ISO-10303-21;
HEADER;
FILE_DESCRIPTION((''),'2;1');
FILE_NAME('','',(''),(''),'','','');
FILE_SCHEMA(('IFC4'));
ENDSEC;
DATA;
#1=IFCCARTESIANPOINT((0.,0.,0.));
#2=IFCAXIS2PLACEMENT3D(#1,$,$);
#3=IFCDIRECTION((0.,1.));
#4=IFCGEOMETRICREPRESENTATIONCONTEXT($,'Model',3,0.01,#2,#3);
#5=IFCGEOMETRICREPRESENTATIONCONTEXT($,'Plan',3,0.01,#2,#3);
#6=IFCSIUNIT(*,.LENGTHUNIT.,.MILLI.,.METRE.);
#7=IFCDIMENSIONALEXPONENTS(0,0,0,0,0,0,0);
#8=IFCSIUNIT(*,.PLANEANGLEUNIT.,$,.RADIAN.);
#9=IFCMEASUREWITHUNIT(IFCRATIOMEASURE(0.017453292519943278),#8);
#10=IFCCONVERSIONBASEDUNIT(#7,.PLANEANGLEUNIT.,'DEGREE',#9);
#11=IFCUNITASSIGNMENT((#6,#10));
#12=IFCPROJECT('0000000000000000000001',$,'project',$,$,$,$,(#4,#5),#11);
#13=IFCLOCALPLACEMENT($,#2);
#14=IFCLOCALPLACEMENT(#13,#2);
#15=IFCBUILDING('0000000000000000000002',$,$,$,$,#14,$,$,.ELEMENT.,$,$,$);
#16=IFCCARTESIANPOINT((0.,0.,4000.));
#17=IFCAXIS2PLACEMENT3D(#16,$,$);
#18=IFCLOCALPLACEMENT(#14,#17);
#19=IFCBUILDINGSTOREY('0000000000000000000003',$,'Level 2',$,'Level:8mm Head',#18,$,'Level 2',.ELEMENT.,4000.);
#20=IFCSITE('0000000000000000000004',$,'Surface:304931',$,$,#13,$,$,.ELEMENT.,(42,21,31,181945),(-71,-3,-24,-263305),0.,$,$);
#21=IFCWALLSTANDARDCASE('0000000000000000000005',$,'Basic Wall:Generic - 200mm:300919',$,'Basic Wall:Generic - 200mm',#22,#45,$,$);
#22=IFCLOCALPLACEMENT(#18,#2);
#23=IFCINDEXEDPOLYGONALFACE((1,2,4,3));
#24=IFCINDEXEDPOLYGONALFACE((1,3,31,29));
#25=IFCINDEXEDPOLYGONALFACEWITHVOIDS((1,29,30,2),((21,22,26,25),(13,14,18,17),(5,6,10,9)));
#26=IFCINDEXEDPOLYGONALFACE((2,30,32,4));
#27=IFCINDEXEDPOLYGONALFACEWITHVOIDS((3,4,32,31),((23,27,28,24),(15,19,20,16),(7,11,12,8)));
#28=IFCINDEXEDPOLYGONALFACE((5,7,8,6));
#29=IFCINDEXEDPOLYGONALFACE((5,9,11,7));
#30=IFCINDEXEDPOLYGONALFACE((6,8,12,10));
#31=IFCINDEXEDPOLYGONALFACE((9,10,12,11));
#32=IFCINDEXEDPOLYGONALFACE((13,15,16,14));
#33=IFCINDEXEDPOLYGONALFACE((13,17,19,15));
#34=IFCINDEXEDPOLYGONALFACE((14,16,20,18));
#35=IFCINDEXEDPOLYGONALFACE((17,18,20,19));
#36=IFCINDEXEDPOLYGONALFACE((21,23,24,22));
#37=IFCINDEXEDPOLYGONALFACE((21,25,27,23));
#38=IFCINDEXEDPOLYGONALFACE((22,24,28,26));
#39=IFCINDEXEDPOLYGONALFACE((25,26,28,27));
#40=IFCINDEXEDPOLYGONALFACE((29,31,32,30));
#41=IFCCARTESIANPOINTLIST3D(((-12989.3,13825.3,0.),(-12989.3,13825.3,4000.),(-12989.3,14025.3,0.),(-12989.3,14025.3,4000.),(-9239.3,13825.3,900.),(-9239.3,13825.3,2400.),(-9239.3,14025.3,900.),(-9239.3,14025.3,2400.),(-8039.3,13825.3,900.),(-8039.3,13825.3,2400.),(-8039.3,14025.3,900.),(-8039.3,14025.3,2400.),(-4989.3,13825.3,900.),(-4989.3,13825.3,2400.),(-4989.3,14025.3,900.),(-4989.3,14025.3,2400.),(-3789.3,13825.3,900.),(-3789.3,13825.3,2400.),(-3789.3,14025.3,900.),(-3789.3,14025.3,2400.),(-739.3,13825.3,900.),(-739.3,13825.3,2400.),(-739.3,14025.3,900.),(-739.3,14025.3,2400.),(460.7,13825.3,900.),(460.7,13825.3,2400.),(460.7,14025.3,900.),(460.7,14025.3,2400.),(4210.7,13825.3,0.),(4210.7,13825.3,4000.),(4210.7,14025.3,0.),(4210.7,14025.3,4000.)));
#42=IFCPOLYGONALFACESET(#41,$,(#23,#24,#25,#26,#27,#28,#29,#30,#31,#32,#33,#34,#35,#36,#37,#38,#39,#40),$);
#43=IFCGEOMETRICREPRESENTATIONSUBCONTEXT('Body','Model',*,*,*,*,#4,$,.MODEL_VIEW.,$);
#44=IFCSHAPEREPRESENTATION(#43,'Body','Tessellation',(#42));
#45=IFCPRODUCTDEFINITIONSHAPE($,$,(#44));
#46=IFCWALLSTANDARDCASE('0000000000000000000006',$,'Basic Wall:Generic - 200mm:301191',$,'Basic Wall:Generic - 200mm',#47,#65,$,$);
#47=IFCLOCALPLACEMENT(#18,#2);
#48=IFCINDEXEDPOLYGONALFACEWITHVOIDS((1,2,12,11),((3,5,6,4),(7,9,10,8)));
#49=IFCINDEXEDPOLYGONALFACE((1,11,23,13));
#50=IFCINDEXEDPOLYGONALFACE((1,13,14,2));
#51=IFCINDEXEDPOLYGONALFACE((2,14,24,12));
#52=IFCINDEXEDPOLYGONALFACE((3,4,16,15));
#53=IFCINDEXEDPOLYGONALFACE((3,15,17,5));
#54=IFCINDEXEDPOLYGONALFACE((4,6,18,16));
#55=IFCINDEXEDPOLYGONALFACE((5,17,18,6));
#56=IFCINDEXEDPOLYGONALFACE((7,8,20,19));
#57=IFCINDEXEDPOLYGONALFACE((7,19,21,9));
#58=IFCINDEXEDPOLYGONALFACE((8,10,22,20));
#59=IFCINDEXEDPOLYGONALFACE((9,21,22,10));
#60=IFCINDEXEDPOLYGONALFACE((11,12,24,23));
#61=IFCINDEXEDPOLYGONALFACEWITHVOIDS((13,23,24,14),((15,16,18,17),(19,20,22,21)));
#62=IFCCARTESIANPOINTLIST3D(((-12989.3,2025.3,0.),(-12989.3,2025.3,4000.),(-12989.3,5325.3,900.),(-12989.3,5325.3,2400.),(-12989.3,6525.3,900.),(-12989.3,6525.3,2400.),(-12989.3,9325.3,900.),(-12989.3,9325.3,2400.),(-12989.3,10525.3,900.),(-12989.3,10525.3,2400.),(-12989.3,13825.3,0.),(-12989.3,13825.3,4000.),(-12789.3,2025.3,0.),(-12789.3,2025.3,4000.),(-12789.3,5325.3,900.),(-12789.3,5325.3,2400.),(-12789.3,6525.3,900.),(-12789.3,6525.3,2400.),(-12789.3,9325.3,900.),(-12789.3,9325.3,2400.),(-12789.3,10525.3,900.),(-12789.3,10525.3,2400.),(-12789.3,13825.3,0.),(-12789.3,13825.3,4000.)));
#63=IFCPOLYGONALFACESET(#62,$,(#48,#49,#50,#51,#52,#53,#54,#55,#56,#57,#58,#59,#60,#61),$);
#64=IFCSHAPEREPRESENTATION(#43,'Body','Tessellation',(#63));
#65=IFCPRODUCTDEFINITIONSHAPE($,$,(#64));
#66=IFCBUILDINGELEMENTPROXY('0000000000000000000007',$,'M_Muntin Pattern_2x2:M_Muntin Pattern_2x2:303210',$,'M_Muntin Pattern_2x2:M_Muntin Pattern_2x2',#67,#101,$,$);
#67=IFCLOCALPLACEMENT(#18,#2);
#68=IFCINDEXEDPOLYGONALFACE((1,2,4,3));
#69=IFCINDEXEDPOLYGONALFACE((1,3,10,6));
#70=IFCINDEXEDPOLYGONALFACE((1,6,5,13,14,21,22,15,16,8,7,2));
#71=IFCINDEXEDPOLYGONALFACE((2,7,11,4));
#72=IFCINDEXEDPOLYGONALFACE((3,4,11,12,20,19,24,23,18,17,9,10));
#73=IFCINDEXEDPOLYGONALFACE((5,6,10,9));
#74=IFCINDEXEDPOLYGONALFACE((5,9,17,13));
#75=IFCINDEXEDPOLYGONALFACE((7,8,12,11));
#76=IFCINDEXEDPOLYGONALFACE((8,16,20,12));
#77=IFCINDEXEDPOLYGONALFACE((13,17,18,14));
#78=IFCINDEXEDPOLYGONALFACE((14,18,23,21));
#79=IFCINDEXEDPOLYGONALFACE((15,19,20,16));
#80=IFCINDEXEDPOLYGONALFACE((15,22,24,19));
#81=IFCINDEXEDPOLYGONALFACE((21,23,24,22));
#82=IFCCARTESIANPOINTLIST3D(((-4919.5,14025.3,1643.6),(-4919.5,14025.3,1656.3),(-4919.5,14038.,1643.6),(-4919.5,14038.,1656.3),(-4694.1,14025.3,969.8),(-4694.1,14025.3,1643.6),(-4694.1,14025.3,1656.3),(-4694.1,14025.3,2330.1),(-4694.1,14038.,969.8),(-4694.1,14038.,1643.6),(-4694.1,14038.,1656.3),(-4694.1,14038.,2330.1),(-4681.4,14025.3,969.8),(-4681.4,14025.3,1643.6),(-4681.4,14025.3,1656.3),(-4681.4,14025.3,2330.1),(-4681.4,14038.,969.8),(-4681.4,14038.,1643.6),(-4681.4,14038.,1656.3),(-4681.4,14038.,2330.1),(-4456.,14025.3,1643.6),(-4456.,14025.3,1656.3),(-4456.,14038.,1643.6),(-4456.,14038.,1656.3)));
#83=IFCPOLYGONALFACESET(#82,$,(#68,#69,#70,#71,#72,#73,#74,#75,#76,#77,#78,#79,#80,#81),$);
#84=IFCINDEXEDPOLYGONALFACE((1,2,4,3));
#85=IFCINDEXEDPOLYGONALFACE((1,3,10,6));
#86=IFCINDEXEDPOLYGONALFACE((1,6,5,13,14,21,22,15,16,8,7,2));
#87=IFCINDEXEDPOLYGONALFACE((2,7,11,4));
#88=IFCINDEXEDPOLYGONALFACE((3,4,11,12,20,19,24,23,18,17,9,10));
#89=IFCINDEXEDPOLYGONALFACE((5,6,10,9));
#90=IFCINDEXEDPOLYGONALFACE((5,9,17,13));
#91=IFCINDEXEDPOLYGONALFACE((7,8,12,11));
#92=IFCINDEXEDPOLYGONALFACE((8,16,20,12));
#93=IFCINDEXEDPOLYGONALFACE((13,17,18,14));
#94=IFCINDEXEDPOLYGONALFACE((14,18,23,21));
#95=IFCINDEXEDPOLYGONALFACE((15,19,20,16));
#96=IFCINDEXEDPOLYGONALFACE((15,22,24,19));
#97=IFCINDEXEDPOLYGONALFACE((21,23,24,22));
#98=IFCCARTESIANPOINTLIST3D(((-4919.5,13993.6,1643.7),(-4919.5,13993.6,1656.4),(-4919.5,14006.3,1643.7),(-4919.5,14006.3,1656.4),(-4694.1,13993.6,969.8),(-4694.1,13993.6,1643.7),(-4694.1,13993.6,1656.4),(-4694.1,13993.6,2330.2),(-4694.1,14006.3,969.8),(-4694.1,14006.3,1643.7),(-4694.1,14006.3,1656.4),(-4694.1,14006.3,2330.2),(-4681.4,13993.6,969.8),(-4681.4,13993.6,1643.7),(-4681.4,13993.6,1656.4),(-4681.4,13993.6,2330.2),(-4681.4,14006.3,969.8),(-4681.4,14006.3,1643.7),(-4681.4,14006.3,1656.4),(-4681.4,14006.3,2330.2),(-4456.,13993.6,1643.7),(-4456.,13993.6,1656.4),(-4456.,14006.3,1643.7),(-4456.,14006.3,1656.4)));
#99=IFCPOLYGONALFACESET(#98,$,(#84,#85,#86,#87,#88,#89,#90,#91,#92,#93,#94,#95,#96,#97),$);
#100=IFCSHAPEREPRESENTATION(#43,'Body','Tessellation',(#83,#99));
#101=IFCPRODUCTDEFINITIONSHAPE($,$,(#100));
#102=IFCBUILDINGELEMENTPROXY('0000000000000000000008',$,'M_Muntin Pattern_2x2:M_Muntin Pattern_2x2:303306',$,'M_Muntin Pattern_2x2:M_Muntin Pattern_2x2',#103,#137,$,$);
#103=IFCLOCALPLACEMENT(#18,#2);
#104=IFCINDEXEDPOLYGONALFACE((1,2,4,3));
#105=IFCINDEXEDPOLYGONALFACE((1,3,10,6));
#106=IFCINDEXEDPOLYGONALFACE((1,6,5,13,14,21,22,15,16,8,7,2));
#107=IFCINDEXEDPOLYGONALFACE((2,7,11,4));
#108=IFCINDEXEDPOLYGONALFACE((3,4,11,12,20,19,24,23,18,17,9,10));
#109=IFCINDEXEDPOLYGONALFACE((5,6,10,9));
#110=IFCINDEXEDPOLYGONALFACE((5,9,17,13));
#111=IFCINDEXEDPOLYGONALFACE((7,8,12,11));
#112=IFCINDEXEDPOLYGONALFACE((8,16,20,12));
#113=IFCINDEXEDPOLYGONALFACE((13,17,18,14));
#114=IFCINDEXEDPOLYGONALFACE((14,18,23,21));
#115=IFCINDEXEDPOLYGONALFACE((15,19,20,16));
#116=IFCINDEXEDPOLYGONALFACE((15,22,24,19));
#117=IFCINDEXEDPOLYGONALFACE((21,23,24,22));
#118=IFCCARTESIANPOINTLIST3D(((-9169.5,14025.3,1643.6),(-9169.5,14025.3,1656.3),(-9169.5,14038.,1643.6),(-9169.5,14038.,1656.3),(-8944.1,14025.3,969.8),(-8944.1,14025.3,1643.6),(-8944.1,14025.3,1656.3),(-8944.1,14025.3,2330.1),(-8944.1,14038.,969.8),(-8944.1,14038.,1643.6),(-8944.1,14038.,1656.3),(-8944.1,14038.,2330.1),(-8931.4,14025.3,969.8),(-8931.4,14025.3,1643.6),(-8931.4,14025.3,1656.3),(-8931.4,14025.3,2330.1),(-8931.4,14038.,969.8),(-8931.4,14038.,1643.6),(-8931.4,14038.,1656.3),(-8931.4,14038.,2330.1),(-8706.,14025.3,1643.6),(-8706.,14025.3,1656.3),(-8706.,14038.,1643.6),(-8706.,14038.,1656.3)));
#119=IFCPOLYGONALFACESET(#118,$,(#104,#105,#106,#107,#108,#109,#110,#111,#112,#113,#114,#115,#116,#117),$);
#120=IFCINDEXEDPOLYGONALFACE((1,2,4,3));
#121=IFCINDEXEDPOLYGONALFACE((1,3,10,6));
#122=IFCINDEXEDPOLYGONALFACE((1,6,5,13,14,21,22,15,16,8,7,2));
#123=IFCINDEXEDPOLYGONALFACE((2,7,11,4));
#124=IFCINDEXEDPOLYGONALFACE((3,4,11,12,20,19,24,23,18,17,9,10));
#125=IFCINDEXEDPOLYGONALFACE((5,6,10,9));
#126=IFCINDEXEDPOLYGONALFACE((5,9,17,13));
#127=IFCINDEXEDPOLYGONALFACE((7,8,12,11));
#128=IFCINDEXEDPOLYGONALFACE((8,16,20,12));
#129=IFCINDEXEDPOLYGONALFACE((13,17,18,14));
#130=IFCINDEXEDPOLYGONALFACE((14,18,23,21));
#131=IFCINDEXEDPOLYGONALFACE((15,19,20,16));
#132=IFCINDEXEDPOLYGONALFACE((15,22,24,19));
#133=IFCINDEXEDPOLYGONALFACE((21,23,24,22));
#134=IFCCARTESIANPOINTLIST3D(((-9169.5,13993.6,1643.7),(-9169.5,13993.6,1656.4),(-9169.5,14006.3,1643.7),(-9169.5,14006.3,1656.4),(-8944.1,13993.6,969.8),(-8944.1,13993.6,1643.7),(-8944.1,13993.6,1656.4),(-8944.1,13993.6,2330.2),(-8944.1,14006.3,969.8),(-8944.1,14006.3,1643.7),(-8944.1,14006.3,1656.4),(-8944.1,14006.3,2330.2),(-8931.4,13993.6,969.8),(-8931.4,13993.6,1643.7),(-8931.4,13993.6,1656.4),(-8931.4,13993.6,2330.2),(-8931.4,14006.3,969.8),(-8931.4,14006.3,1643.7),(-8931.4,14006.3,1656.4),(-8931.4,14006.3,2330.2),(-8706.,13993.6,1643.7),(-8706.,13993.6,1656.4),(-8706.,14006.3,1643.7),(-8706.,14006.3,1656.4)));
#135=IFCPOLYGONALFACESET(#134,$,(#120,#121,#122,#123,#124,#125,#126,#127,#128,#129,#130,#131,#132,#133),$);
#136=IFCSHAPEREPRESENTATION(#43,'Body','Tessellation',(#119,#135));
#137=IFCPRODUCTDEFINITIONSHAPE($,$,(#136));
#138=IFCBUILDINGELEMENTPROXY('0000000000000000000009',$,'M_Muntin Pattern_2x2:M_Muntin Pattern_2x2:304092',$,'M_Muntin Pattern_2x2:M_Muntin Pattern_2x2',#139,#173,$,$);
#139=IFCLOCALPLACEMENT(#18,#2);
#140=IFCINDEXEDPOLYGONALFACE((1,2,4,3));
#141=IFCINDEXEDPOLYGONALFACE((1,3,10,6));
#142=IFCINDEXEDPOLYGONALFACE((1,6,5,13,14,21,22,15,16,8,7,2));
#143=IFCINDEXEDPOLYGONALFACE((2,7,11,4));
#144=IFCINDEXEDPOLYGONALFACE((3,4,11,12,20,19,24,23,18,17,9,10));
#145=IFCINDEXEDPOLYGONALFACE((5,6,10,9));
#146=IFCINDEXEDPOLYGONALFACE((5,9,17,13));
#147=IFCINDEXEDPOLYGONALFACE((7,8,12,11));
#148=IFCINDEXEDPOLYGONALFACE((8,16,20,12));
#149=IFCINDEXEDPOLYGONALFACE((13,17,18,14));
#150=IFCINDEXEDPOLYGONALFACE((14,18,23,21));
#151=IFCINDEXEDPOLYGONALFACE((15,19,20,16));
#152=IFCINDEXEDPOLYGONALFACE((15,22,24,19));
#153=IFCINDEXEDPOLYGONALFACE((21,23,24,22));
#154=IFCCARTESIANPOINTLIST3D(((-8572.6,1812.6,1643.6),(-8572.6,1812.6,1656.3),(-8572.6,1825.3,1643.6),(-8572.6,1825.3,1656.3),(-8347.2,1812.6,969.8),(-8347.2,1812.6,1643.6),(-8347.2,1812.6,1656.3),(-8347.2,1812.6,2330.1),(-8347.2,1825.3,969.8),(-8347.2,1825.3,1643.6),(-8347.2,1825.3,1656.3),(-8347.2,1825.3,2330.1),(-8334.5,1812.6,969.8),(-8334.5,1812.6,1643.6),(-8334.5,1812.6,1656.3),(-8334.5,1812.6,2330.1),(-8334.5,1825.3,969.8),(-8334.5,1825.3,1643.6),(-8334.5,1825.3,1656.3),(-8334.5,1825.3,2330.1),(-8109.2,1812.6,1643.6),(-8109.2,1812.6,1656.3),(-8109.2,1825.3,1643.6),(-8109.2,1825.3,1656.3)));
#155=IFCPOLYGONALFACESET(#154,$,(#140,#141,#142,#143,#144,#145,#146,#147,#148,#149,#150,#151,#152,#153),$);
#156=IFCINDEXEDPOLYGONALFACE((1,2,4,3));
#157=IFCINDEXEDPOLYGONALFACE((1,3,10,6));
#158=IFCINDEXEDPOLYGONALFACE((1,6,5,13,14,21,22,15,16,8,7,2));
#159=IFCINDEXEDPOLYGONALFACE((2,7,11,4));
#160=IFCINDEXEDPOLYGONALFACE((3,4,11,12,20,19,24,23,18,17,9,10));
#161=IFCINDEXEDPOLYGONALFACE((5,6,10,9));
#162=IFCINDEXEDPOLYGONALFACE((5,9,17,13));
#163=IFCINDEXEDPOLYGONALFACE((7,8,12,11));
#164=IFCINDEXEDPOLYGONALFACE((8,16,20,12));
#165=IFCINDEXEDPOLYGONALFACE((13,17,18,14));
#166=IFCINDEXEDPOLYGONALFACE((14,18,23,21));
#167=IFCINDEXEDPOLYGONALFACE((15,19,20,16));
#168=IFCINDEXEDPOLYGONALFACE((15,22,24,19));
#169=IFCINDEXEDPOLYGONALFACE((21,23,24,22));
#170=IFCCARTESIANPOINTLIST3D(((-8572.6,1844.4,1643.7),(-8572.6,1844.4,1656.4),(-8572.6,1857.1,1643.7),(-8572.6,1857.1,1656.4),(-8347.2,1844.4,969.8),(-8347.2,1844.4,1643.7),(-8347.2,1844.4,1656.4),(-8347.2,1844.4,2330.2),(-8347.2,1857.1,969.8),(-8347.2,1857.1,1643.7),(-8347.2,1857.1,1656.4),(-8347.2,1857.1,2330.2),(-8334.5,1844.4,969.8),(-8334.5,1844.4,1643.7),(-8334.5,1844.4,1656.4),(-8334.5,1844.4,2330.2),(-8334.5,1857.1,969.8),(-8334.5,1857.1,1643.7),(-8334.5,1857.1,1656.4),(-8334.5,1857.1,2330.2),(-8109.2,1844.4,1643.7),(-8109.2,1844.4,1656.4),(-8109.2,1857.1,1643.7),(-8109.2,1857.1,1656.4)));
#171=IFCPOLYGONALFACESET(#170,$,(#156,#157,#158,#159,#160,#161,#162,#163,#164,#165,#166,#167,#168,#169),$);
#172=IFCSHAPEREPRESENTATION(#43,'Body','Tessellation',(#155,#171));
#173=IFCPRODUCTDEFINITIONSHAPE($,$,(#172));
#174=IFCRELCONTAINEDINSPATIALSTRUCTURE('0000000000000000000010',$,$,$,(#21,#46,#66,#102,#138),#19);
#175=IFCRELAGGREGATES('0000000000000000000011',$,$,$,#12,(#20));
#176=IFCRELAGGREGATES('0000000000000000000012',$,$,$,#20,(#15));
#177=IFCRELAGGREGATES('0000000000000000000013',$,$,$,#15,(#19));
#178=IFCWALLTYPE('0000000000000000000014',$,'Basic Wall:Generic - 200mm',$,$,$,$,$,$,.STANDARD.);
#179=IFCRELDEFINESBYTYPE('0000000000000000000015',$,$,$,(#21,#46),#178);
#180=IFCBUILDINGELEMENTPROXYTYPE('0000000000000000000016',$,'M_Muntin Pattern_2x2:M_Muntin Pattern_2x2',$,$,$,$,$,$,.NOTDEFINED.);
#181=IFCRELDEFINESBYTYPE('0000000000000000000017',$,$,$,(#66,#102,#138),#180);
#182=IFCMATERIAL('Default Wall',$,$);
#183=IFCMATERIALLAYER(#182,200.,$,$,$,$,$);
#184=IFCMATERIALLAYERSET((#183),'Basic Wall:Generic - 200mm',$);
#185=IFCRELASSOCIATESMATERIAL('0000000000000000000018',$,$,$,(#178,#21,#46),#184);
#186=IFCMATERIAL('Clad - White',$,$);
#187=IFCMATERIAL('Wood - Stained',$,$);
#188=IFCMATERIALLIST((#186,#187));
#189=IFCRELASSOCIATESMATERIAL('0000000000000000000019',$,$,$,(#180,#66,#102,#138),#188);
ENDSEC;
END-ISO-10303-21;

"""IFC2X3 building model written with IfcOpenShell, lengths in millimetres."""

from ifc_helpers import new_model, entity, si_unit, converted_unit, direction, frame, frame_2d, origin, place, context, subcontext, project, spatial, polyline, rectangle, outline, extrude, source, transform, mapped, material, material_list, layer, layer_set, layer_usage, type_object, type_shapes, element, save


model = new_model("IFC2X3")

# Units and contexts
model_context = context("Model", 3, precision=0.01, world=origin(), true_north=direction((0.0, 1.0)))
plan_context = context("Plan", 3, precision=0.01, world=origin(), true_north=direction((0.0, 1.0)))
body_context = subcontext(model_context, "Body", "Model", "MODEL_VIEW")
ifc_project = project(units=[si_unit("LENGTHUNIT", "METRE", prefix="MILLI"), converted_unit("PLANEANGLEUNIT", "DEGREE", entity("IfcRatioMeasure", 0.017453292519943278), si_unit("PLANEANGLEUNIT", "RADIAN"), dimensions=[0, 0, 0, 0, 0, 0, 0])], contexts=[model_context, plan_context])

# Site, building, storey
site_placement = place(None, origin())
site = spatial("IfcSite", under=ifc_project, at=site_placement, Name="Surface:304931", CompositionType="ELEMENT", RefLatitude=(42, 21, 31, 181945), RefLongitude=(-71, -3, -24, -263305), RefElevation=0.0)
building_placement = place(site_placement, origin())
building = spatial("IfcBuilding", under=site, at=building_placement, CompositionType="ELEMENT")
storey_placement = place(building_placement, frame((0.0, 0.0, 4000.0)))
storey = spatial("IfcBuildingStorey", under=building, at=storey_placement, Name="Level 2", ObjectType="Level:8mm Head", LongName="Level 2", CompositionType="ELEMENT", Elevation=4000.0)

# Walls, openings
ifc_material_1 = material(Name="Default Wall")
ifc_layer = layer(ifc_material_1, 200.0)
ifc_layer_set = layer_set([ifc_layer], Name="Basic Wall:Generic - 200mm")
ifc_layer_usage = layer_usage(ifc_layer_set, "AXIS2", "NEGATIVE", 100.0)
wall_type = type_object("IfcWallType", Name="Basic Wall:Generic - 200mm", PredefinedType="STANDARD", material=ifc_layer_set)
wall_1_placement = place(storey_placement, frame((-12989.3, 13925.3, 0.0)))
wall_1 = element("IfcWallStandardCase", 1, at=wall_1_placement, inside=storey, type_object=wall_type, material=ifc_layer_usage, Name="Basic Wall:Generic - 200mm:300919", ObjectType="Basic Wall:Generic - 200mm", context=body_context, shape_type="SweptSolid", body=[
    extrude(rectangle(XDim=17200.0, YDim=200.0, at=frame_2d((8600.0, 0.0), x_axis=(-1.0, 0.0))), origin(), (0.0, 0.0, 1.0), 4000.0),
])
opening_1_placement = place(wall_1_placement, frame((12250.0, -100.0, 900.0)))
element("IfcOpeningElement", 2, at=opening_1_placement, cuts=wall_1, ObjectType="Opening", context=body_context, shape_type="SweptSolid", body=[
    extrude(rectangle(XDim=1500.0, YDim=1200.0, at=frame_2d((750.0, 600.0), x_axis=(-1.0, 0.0))), frame((0.0, 0.0, 0.0), z_axis=(0.0, 1.0, 0.0), x_axis=(0.0, 0.0, 1.0)), (0.0, 0.0, 1.0), 200.0),
])
opening_2_placement = place(wall_1_placement, frame((8000.0, -100.0, 900.0)))
element("IfcOpeningElement", 3, at=opening_2_placement, cuts=wall_1, ObjectType="Opening", context=body_context, shape_type="SweptSolid", body=[
    extrude(rectangle(XDim=1500.0, YDim=1200.0, at=frame_2d((750.0, 600.0), x_axis=(-1.0, 0.0))), frame((0.0, 0.0, 0.0), z_axis=(0.0, 1.0, 0.0), x_axis=(0.0, 0.0, 1.0)), (0.0, 0.0, 1.0), 200.0),
])
opening_3_placement = place(wall_1_placement, frame((3750.0, -100.0, 900.0)))
element("IfcOpeningElement", 4, at=opening_3_placement, cuts=wall_1, ObjectType="Opening", context=body_context, shape_type="SweptSolid", body=[
    extrude(rectangle(XDim=1500.0, YDim=1200.0, at=frame_2d((750.0, 600.0), x_axis=(-1.0, 0.0))), frame((0.0, 0.0, 0.0), z_axis=(0.0, 1.0, 0.0), x_axis=(0.0, 0.0, 1.0)), (0.0, 0.0, 1.0), 200.0),
])
wall_2_placement = place(storey_placement, frame((-12889.3, 2025.3, 0.0), z_axis=(0.0, 0.0, 1.0), x_axis=(0.0, 1.0, 0.0)))
wall_2 = element("IfcWallStandardCase", 5, at=wall_2_placement, inside=storey, type_object=wall_type, material=ifc_layer_usage, Name="Basic Wall:Generic - 200mm:301191", ObjectType="Basic Wall:Generic - 200mm", context=body_context, shape_type="SweptSolid", body=[
    extrude(rectangle(XDim=11800.0, YDim=200.0, at=frame_2d((5900.0, 0.0), x_axis=(-1.0, 0.0))), origin(), (0.0, 0.0, 1.0), 4000.0),
])
opening_4_placement = place(wall_2_placement, frame((3300.0, -100.0, 900.0)))
element("IfcOpeningElement", 6, at=opening_4_placement, cuts=wall_2, ObjectType="Opening", context=body_context, shape_type="SweptSolid", body=[
    extrude(rectangle(XDim=1500.0, YDim=1200.0, at=frame_2d((750.0, 600.0), x_axis=(-1.0, 0.0))), frame((0.0, 0.0, 0.0), z_axis=(0.0, 1.0, 0.0), x_axis=(0.0, 0.0, 1.0)), (0.0, 0.0, 1.0), 200.0),
])
opening_5_placement = place(wall_2_placement, frame((7300.0, -100.0, 900.0)))
element("IfcOpeningElement", 7, at=opening_5_placement, cuts=wall_2, ObjectType="Opening", context=body_context, shape_type="SweptSolid", body=[
    extrude(rectangle(XDim=1500.0, YDim=1200.0, at=frame_2d((750.0, 600.0), x_axis=(-1.0, 0.0))), frame((0.0, 0.0, 0.0), z_axis=(0.0, 1.0, 0.0), x_axis=(0.0, 0.0, 1.0)), (0.0, 0.0, 1.0), 200.0),
])

# Building element proxies
ifc_material_2 = material(Name="Clad - White")
ifc_material_3 = material(Name="Wood - Stained")
ifc_material_list = material_list([ifc_material_2, ifc_material_3])
building_element_proxy_type_1 = type_object("IfcBuildingElementProxyType", Name="M_Muntin Pattern_2x2:M_Muntin Pattern_2x2", PredefinedType="NOTDEFINED", material=ifc_material_list)
shared_shape_1 = source(origin(), body_context, "Body", "SweptSolid", [
    extrude(outline(polyline([(6.4, -6.4), (680.1, -6.4), (680.1, 6.3), (6.4, 6.3), (6.4, 231.7), (-6.3, 231.7), (-6.3, 6.3), (-680.2, 6.3), (-680.2, -6.4), (-6.3, -6.4), (-6.3, -231.7), (6.4, -231.7), (6.4, -6.4)])), frame((0.0, 9.5, 680.1), z_axis=(0.0, 1.0, 0.0), x_axis=(0.0, 0.0, 1.0)), (0.0, 0.0, 1.0), 12.7),
    extrude(outline(polyline([(6.4, -6.4), (680.2, -6.4), (680.2, 6.3), (6.4, 6.3), (6.4, 231.7), (-6.3, 231.7), (-6.3, 6.3), (-680.2, 6.3), (-680.2, -6.4), (-6.3, -6.4), (-6.3, -231.7), (6.4, -231.7), (6.4, -6.4)])), frame((0.0, -22.2, 680.2), z_axis=(0.0, 1.0, 0.0), x_axis=(0.0, 0.0, 1.0)), (0.0, 0.0, 1.0), 12.7),
])
type_shapes(building_element_proxy_type_1, [shared_shape_1])
for number, where, name in (
    (8, (-4687.7, 14015.8, 969.8), "M_Muntin Pattern_2x2:M_Muntin Pattern_2x2:303210"),
    (9, (-8937.7, 14015.8, 969.8), "M_Muntin Pattern_2x2:M_Muntin Pattern_2x2:303306"),
):
    element("IfcBuildingElementProxy", number, at=place(storey_placement, frame(where)), inside=storey, type_object=building_element_proxy_type_1, material=ifc_material_list, Name=name, ObjectType="M_Muntin Pattern_2x2:M_Muntin Pattern_2x2", context=body_context, shape_type="MappedRepresentation", body=[
        mapped(shared_shape_1, transform((0.0, 0.0, 0.0), scale=1.0)),
    ])
for number, where, z_axis, x_axis, name in (
    (10, (-8340.9, 1834.8, 969.8), (0.0, 0.0, 1.0), (-1.0, 0.0, 0.0), "M_Muntin Pattern_2x2:M_Muntin Pattern_2x2:304092"),
):
    element("IfcBuildingElementProxy", number, at=place(storey_placement, frame(where, z_axis=z_axis, x_axis=x_axis)), inside=storey, type_object=building_element_proxy_type_1, material=ifc_material_list, Name=name, ObjectType="M_Muntin Pattern_2x2:M_Muntin Pattern_2x2", context=body_context, shape_type="MappedRepresentation", body=[
        mapped(shared_shape_1, transform((0.0, 0.0, 0.0), scale=1.0)),
    ])

save(model, "model.ifc")
